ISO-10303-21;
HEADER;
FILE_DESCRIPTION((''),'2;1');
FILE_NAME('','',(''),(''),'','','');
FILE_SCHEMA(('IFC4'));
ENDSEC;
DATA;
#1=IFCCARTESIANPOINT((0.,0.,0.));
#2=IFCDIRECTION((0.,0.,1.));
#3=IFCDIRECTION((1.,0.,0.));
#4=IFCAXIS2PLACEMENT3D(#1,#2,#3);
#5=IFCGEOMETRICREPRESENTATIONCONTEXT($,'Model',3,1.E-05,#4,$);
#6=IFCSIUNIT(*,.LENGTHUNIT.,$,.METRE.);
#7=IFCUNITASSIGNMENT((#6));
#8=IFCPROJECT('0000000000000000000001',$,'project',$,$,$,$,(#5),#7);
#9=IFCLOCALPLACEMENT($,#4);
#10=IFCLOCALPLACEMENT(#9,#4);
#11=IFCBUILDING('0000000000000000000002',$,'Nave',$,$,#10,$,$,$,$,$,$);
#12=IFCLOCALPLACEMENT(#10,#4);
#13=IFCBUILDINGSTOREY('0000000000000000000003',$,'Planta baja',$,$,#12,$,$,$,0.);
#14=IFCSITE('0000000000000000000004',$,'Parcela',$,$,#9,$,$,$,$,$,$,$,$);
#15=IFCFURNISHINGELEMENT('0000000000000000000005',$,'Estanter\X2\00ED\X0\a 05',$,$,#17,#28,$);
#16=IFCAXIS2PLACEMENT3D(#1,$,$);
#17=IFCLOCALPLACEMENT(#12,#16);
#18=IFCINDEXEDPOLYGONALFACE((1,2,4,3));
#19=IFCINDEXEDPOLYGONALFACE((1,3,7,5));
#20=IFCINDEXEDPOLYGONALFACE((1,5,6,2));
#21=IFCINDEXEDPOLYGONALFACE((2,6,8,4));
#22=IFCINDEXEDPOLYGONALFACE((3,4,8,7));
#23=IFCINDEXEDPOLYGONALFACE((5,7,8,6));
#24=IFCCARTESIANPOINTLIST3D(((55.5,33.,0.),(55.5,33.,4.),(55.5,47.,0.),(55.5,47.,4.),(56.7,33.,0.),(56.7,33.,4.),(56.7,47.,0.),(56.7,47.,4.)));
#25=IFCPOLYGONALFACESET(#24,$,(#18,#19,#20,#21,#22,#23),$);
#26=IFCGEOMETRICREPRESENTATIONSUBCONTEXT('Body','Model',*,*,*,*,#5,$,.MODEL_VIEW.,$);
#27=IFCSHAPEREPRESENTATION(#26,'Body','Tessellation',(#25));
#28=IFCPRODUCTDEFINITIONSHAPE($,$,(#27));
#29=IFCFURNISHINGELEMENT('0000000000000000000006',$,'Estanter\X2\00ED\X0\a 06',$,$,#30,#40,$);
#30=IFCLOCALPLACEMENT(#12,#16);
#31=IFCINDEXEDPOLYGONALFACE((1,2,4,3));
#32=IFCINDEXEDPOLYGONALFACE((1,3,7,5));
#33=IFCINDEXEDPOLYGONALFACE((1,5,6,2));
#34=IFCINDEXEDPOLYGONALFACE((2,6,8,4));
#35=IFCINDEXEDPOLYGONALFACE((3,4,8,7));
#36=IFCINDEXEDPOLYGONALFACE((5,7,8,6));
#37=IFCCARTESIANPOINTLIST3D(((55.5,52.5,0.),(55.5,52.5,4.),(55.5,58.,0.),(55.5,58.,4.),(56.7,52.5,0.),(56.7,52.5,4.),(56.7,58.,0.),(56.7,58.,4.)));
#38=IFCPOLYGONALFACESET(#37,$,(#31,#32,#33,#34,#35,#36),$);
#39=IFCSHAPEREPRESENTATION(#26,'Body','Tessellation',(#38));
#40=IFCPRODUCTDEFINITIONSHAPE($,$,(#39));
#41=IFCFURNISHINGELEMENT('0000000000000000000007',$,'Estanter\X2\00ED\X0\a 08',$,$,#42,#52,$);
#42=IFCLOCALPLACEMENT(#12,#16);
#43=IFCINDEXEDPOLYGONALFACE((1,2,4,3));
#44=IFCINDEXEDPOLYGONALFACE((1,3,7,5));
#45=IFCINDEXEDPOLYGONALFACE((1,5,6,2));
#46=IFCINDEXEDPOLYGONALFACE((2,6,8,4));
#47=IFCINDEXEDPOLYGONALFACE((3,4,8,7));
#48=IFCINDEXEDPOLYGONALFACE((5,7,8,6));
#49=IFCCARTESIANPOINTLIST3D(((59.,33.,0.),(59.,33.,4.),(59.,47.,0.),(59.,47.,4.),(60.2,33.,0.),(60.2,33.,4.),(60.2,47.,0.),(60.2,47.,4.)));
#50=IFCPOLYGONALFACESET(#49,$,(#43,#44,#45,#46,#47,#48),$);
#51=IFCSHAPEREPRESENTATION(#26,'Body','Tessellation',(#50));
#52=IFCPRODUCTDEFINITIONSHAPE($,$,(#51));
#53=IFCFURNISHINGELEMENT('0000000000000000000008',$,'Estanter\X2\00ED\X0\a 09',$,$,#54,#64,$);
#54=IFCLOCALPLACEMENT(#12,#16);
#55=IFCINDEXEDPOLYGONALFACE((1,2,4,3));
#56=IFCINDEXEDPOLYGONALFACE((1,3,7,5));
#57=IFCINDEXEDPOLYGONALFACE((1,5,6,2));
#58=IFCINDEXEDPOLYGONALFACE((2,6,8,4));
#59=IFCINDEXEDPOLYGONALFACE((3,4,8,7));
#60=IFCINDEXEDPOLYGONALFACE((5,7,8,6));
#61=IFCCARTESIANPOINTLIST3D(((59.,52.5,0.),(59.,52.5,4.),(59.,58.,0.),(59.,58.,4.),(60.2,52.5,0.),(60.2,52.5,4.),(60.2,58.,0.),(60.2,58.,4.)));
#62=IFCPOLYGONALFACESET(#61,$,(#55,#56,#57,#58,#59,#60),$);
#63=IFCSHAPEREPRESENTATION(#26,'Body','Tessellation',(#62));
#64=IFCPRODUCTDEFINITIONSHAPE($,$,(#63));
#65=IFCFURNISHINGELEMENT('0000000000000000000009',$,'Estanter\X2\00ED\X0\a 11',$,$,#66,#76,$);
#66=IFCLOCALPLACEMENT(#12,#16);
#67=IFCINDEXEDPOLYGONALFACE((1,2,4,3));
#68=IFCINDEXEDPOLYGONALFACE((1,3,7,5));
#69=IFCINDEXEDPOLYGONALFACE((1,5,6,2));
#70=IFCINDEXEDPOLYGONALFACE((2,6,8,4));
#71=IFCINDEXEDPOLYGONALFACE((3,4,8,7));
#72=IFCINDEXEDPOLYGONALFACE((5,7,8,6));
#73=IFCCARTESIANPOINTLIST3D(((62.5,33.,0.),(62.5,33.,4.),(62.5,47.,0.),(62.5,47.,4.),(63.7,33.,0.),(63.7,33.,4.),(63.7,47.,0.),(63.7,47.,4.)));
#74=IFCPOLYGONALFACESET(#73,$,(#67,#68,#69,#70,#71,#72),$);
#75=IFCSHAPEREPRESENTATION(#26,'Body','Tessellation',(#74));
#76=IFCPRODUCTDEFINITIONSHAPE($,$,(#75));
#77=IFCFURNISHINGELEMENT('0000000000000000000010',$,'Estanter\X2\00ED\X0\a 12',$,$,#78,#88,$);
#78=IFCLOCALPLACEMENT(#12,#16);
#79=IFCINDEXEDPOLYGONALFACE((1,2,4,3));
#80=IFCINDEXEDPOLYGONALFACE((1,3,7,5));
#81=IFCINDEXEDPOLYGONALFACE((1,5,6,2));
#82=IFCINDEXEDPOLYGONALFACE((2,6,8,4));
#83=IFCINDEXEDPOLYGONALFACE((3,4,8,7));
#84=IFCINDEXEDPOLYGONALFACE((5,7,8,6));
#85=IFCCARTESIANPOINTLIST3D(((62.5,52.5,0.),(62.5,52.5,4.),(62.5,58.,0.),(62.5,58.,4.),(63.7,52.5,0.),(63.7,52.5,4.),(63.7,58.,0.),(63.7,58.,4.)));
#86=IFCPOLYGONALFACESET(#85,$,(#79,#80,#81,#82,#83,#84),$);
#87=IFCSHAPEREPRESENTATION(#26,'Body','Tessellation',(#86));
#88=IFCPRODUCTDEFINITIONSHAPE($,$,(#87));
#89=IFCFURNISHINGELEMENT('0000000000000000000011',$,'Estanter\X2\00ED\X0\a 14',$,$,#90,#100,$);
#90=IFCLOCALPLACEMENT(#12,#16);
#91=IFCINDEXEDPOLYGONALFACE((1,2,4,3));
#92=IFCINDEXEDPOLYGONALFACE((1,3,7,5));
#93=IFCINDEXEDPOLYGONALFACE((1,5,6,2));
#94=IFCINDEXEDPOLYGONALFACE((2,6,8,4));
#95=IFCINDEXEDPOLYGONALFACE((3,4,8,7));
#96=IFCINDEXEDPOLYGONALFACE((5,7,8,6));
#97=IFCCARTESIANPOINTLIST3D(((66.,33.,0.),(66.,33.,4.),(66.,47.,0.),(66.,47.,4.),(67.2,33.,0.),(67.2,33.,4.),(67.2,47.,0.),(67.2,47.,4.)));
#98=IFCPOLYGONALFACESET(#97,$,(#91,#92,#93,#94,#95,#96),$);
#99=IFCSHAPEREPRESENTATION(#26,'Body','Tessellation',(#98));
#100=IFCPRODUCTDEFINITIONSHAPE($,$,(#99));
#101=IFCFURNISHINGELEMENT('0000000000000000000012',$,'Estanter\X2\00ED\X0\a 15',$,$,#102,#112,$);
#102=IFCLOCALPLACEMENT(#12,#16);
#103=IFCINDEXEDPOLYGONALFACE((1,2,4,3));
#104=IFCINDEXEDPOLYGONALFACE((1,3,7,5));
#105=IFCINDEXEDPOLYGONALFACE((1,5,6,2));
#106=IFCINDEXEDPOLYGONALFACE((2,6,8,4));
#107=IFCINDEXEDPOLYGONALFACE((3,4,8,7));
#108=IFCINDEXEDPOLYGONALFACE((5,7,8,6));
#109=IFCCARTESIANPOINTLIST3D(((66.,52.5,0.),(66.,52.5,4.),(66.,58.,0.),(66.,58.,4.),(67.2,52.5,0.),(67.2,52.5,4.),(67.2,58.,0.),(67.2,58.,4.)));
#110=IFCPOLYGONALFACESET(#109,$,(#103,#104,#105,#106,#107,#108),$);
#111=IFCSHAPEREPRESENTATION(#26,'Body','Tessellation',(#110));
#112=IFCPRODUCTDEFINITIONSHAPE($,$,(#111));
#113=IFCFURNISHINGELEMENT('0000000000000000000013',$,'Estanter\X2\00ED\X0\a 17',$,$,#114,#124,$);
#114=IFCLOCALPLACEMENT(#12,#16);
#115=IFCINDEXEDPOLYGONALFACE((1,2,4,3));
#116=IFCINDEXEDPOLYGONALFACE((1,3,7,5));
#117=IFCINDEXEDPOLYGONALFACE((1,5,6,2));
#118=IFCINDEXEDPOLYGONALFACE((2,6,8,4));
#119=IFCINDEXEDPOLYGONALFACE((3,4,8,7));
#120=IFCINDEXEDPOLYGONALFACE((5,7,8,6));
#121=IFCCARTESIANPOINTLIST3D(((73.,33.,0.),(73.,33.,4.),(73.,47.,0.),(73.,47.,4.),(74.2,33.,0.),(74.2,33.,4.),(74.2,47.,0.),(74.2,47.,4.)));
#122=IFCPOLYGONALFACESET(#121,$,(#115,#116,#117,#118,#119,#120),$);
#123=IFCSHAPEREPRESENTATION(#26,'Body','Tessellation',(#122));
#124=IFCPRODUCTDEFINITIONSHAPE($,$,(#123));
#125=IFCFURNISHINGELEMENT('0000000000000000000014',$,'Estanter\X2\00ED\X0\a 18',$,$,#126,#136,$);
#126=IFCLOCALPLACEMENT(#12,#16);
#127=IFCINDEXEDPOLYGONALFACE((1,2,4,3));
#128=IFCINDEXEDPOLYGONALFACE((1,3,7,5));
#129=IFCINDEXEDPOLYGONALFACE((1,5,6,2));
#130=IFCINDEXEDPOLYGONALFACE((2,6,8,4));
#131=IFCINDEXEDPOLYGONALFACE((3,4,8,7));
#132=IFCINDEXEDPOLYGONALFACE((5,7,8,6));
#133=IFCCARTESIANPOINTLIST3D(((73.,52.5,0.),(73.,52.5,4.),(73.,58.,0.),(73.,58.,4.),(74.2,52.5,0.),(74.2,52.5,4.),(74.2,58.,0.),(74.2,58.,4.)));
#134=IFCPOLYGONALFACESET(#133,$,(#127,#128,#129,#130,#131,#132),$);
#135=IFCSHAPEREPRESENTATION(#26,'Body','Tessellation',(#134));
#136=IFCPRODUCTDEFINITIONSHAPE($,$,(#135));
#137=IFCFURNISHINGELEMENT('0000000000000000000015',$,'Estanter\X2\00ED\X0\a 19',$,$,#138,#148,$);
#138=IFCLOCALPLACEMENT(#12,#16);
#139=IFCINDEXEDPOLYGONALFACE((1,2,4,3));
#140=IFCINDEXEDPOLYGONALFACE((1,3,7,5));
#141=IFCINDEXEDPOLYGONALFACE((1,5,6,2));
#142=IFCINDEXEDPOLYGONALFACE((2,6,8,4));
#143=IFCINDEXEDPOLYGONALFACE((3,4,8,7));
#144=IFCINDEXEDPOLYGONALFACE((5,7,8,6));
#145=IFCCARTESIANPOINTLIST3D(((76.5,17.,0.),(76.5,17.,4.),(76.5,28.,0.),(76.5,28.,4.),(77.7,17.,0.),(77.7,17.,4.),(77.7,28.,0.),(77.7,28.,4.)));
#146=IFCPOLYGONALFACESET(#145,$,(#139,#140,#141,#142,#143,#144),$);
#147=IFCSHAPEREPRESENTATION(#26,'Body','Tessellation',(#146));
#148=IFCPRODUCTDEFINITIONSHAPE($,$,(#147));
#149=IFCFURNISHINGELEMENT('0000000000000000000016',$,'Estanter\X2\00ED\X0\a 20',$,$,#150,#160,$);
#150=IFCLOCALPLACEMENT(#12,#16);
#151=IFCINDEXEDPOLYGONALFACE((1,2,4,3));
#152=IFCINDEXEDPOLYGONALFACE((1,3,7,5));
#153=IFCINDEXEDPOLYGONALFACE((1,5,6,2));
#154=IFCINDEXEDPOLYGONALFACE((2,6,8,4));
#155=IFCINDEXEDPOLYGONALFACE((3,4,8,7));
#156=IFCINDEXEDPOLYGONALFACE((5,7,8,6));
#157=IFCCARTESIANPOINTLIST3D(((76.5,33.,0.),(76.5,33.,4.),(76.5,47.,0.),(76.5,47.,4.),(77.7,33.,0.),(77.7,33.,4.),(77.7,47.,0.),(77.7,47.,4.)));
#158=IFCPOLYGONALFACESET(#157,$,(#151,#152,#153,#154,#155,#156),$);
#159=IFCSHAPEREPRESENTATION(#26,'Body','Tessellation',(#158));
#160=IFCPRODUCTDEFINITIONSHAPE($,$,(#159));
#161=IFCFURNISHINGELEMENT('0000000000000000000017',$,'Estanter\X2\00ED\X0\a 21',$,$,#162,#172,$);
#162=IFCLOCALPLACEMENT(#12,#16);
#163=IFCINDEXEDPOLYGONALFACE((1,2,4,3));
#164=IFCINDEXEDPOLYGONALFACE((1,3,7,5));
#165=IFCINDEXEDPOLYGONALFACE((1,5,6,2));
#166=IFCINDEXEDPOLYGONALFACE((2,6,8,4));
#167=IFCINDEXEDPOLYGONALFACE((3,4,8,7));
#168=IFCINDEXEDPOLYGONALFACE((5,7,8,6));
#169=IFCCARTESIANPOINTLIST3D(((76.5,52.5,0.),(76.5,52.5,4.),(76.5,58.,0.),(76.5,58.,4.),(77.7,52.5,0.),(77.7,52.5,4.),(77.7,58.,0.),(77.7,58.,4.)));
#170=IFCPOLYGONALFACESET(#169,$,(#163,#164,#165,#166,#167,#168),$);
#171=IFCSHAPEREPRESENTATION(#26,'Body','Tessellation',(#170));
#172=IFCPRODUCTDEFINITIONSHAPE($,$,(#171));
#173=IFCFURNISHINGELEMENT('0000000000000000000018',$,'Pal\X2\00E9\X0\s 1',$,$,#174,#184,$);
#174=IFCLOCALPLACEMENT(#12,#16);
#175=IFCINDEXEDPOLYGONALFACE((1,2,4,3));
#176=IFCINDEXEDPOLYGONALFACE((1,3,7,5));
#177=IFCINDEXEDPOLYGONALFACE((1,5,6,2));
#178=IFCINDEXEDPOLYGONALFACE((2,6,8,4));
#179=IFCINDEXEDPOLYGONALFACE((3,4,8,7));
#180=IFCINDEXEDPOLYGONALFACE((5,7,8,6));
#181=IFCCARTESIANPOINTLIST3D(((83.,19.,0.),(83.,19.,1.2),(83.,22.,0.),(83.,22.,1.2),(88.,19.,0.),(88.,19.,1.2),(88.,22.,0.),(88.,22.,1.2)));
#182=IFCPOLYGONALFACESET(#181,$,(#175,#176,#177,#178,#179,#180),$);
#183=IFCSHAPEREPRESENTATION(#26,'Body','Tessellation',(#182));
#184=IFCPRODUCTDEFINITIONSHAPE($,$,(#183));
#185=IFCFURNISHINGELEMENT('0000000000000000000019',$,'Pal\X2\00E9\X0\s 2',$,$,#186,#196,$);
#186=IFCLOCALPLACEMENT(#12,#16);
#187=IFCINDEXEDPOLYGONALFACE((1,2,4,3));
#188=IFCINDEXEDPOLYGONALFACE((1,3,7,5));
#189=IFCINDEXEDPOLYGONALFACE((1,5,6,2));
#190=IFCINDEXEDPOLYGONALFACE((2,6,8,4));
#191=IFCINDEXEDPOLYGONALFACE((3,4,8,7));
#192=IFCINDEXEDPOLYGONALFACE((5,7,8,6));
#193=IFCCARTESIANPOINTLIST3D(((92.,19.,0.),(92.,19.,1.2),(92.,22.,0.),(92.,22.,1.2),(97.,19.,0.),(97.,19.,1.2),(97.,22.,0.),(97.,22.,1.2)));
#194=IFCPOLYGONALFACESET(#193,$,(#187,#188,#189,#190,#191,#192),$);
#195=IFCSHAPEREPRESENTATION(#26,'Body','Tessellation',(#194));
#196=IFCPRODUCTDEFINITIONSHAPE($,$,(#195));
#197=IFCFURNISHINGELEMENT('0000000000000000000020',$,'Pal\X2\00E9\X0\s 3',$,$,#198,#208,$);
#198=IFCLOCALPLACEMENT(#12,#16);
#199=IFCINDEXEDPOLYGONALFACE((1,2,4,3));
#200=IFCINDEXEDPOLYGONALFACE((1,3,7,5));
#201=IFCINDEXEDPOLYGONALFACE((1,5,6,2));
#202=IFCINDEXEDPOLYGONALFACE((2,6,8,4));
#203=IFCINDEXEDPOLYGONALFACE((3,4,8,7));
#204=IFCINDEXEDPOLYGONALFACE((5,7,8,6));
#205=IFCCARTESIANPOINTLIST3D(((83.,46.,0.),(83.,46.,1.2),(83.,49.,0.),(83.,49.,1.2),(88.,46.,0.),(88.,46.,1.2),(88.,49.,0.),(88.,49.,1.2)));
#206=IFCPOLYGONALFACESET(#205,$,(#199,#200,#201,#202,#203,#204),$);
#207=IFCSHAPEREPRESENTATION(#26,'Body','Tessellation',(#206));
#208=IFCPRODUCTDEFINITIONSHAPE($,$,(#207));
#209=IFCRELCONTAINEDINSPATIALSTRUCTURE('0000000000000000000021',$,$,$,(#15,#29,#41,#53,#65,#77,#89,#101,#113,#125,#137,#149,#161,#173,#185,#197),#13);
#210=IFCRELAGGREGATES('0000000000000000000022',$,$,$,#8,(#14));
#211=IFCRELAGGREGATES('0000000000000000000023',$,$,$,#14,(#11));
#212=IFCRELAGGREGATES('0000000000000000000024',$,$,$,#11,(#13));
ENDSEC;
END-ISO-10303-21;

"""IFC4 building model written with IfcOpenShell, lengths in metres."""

from ifc_helpers import new_model, si_unit, frame, origin_with_axes, place, context, subcontext, project, spatial, indexed_curve, outline, extrude, element, save


model = new_model("IFC4")

# Units and contexts
model_context = context("Model", 3, precision=1e-05, world=origin_with_axes())
body_context = subcontext(model_context, "Body", "Model", "MODEL_VIEW")
ifc_project = project(units=[si_unit("LENGTHUNIT", "METRE")], contexts=[model_context])

# Site, building, storey
site_placement = place(None, origin_with_axes())
site = spatial("IfcSite", under=ifc_project, at=site_placement, Name="Parcela")
building_placement = place(site_placement, origin_with_axes())
building = spatial("IfcBuilding", under=site, at=building_placement, Name="Nave")
storey_placement = place(building_placement, origin_with_axes())
storey = spatial("IfcBuildingStorey", under=building, at=storey_placement, Name="Planta baja", Elevation=0.0)

# Furnishing elements
furnishing_1_placement = place(storey_placement, frame((55.5, 33.0, 0.0), z_axis=(0.0, 0.0, 1.0), x_axis=(1.0, 0.0, 0.0)))
element("IfcFurnishingElement", 1, at=furnishing_1_placement, inside=storey, Name="Estantería 05", context=body_context, shape_type="SweptSolid", body=[
    extrude(outline(indexed_curve([(0.0, 0.0), (0.0, 14.0), (1.2, 14.0), (1.2, 0.0), (0.0, 0.0)], self_intersect=False)), origin_with_axes(), (0.0, 0.0, 1.0), 4.0),
])
furnishing_2_placement = place(storey_placement, frame((55.5, 52.5, 0.0), z_axis=(0.0, 0.0, 1.0), x_axis=(1.0, 0.0, 0.0)))
element("IfcFurnishingElement", 2, at=furnishing_2_placement, inside=storey, Name="Estantería 06", context=body_context, shape_type="SweptSolid", body=[
    extrude(outline(indexed_curve([(0.0, 0.0), (0.0, 5.5), (1.2, 5.5), (1.2, 0.0), (0.0, 0.0)], self_intersect=False)), origin_with_axes(), (0.0, 0.0, 1.0), 4.0),
])
furnishing_3_placement = place(storey_placement, frame((59.0, 33.0, 0.0), z_axis=(0.0, 0.0, 1.0), x_axis=(1.0, 0.0, 0.0)))
element("IfcFurnishingElement", 3, at=furnishing_3_placement, inside=storey, Name="Estantería 08", context=body_context, shape_type="SweptSolid", body=[
    extrude(outline(indexed_curve([(0.0, 0.0), (0.0, 14.0), (1.2, 14.0), (1.2, 0.0), (0.0, 0.0)], self_intersect=False)), origin_with_axes(), (0.0, 0.0, 1.0), 4.0),
])
furnishing_4_placement = place(storey_placement, frame((59.0, 52.5, 0.0), z_axis=(0.0, 0.0, 1.0), x_axis=(1.0, 0.0, 0.0)))
element("IfcFurnishingElement", 4, at=furnishing_4_placement, inside=storey, Name="Estantería 09", context=body_context, shape_type="SweptSolid", body=[
    extrude(outline(indexed_curve([(0.0, 0.0), (0.0, 5.5), (1.2, 5.5), (1.2, 0.0), (0.0, 0.0)], self_intersect=False)), origin_with_axes(), (0.0, 0.0, 1.0), 4.0),
])
furnishing_5_placement = place(storey_placement, frame((62.5, 33.0, 0.0), z_axis=(0.0, 0.0, 1.0), x_axis=(1.0, 0.0, 0.0)))
element("IfcFurnishingElement", 5, at=furnishing_5_placement, inside=storey, Name="Estantería 11", context=body_context, shape_type="SweptSolid", body=[
    extrude(outline(indexed_curve([(0.0, 0.0), (0.0, 14.0), (1.2, 14.0), (1.2, 0.0), (0.0, 0.0)], self_intersect=False)), origin_with_axes(), (0.0, 0.0, 1.0), 4.0),
])
furnishing_6_placement = place(storey_placement, frame((62.5, 52.5, 0.0), z_axis=(0.0, 0.0, 1.0), x_axis=(1.0, 0.0, 0.0)))
element("IfcFurnishingElement", 6, at=furnishing_6_placement, inside=storey, Name="Estantería 12", context=body_context, shape_type="SweptSolid", body=[
    extrude(outline(indexed_curve([(0.0, 0.0), (0.0, 5.5), (1.2, 5.5), (1.2, 0.0), (0.0, 0.0)], self_intersect=False)), origin_with_axes(), (0.0, 0.0, 1.0), 4.0),
])
furnishing_7_placement = place(storey_placement, frame((66.0, 33.0, 0.0), z_axis=(0.0, 0.0, 1.0), x_axis=(1.0, 0.0, 0.0)))
element("IfcFurnishingElement", 7, at=furnishing_7_placement, inside=storey, Name="Estantería 14", context=body_context, shape_type="SweptSolid", body=[
    extrude(outline(indexed_curve([(0.0, 0.0), (0.0, 14.0), (1.2, 14.0), (1.2, 0.0), (0.0, 0.0)], self_intersect=False)), origin_with_axes(), (0.0, 0.0, 1.0), 4.0),
])
furnishing_8_placement = place(storey_placement, frame((66.0, 52.5, 0.0), z_axis=(0.0, 0.0, 1.0), x_axis=(1.0, 0.0, 0.0)))
element("IfcFurnishingElement", 8, at=furnishing_8_placement, inside=storey, Name="Estantería 15", context=body_context, shape_type="SweptSolid", body=[
    extrude(outline(indexed_curve([(0.0, 0.0), (0.0, 5.5), (1.2, 5.5), (1.2, 0.0), (0.0, 0.0)], self_intersect=False)), origin_with_axes(), (0.0, 0.0, 1.0), 4.0),
])
furnishing_9_placement = place(storey_placement, frame((73.0, 33.0, 0.0), z_axis=(0.0, 0.0, 1.0), x_axis=(1.0, 0.0, 0.0)))
element("IfcFurnishingElement", 9, at=furnishing_9_placement, inside=storey, Name="Estantería 17", context=body_context, shape_type="SweptSolid", body=[
    extrude(outline(indexed_curve([(0.0, 0.0), (0.0, 14.0), (1.2, 14.0), (1.2, 0.0), (0.0, 0.0)], self_intersect=False)), origin_with_axes(), (0.0, 0.0, 1.0), 4.0),
])
furnishing_10_placement = place(storey_placement, frame((73.0, 52.5, 0.0), z_axis=(0.0, 0.0, 1.0), x_axis=(1.0, 0.0, 0.0)))
element("IfcFurnishingElement", 10, at=furnishing_10_placement, inside=storey, Name="Estantería 18", context=body_context, shape_type="SweptSolid", body=[
    extrude(outline(indexed_curve([(0.0, 0.0), (0.0, 5.5), (1.2, 5.5), (1.2, 0.0), (0.0, 0.0)], self_intersect=False)), origin_with_axes(), (0.0, 0.0, 1.0), 4.0),
])
furnishing_11_placement = place(storey_placement, frame((76.5, 17.0, 0.0), z_axis=(0.0, 0.0, 1.0), x_axis=(1.0, 0.0, 0.0)))
element("IfcFurnishingElement", 11, at=furnishing_11_placement, inside=storey, Name="Estantería 19", context=body_context, shape_type="SweptSolid", body=[
    extrude(outline(indexed_curve([(0.0, 0.0), (0.0, 11.0), (1.2, 11.0), (1.2, 0.0), (0.0, 0.0)], self_intersect=False)), origin_with_axes(), (0.0, 0.0, 1.0), 4.0),
])
furnishing_12_placement = place(storey_placement, frame((76.5, 33.0, 0.0), z_axis=(0.0, 0.0, 1.0), x_axis=(1.0, 0.0, 0.0)))
element("IfcFurnishingElement", 12, at=furnishing_12_placement, inside=storey, Name="Estantería 20", context=body_context, shape_type="SweptSolid", body=[
    extrude(outline(indexed_curve([(0.0, 0.0), (0.0, 14.0), (1.2, 14.0), (1.2, 0.0), (0.0, 0.0)], self_intersect=False)), origin_with_axes(), (0.0, 0.0, 1.0), 4.0),
])
furnishing_13_placement = place(storey_placement, frame((76.5, 52.5, 0.0), z_axis=(0.0, 0.0, 1.0), x_axis=(1.0, 0.0, 0.0)))
element("IfcFurnishingElement", 13, at=furnishing_13_placement, inside=storey, Name="Estantería 21", context=body_context, shape_type="SweptSolid", body=[
    extrude(outline(indexed_curve([(0.0, 0.0), (0.0, 5.5), (1.2, 5.5), (1.2, 0.0), (0.0, 0.0)], self_intersect=False)), origin_with_axes(), (0.0, 0.0, 1.0), 4.0),
])
for number, where, z_axis, x_axis, name in (
    (14, (83.0, 19.0, 0.0), (0.0, 0.0, 1.0), (1.0, 0.0, 0.0), "Palés 1"),
    (15, (92.0, 19.0, 0.0), (0.0, 0.0, 1.0), (1.0, 0.0, 0.0), "Palés 2"),
    (16, (83.0, 46.0, 0.0), (0.0, 0.0, 1.0), (1.0, 0.0, 0.0), "Palés 3"),
):
    element("IfcFurnishingElement", number, at=place(storey_placement, frame(where, z_axis=z_axis, x_axis=x_axis)), inside=storey, Name=name, context=body_context, shape_type="SweptSolid", body=[
        extrude(outline(indexed_curve([(0.0, 0.0), (0.0, 3.0), (5.0, 3.0), (5.0, 0.0), (0.0, 0.0)], self_intersect=False)), origin_with_axes(), (0.0, 0.0, 1.0), 1.2),
    ])

save(model, "model.ifc")
